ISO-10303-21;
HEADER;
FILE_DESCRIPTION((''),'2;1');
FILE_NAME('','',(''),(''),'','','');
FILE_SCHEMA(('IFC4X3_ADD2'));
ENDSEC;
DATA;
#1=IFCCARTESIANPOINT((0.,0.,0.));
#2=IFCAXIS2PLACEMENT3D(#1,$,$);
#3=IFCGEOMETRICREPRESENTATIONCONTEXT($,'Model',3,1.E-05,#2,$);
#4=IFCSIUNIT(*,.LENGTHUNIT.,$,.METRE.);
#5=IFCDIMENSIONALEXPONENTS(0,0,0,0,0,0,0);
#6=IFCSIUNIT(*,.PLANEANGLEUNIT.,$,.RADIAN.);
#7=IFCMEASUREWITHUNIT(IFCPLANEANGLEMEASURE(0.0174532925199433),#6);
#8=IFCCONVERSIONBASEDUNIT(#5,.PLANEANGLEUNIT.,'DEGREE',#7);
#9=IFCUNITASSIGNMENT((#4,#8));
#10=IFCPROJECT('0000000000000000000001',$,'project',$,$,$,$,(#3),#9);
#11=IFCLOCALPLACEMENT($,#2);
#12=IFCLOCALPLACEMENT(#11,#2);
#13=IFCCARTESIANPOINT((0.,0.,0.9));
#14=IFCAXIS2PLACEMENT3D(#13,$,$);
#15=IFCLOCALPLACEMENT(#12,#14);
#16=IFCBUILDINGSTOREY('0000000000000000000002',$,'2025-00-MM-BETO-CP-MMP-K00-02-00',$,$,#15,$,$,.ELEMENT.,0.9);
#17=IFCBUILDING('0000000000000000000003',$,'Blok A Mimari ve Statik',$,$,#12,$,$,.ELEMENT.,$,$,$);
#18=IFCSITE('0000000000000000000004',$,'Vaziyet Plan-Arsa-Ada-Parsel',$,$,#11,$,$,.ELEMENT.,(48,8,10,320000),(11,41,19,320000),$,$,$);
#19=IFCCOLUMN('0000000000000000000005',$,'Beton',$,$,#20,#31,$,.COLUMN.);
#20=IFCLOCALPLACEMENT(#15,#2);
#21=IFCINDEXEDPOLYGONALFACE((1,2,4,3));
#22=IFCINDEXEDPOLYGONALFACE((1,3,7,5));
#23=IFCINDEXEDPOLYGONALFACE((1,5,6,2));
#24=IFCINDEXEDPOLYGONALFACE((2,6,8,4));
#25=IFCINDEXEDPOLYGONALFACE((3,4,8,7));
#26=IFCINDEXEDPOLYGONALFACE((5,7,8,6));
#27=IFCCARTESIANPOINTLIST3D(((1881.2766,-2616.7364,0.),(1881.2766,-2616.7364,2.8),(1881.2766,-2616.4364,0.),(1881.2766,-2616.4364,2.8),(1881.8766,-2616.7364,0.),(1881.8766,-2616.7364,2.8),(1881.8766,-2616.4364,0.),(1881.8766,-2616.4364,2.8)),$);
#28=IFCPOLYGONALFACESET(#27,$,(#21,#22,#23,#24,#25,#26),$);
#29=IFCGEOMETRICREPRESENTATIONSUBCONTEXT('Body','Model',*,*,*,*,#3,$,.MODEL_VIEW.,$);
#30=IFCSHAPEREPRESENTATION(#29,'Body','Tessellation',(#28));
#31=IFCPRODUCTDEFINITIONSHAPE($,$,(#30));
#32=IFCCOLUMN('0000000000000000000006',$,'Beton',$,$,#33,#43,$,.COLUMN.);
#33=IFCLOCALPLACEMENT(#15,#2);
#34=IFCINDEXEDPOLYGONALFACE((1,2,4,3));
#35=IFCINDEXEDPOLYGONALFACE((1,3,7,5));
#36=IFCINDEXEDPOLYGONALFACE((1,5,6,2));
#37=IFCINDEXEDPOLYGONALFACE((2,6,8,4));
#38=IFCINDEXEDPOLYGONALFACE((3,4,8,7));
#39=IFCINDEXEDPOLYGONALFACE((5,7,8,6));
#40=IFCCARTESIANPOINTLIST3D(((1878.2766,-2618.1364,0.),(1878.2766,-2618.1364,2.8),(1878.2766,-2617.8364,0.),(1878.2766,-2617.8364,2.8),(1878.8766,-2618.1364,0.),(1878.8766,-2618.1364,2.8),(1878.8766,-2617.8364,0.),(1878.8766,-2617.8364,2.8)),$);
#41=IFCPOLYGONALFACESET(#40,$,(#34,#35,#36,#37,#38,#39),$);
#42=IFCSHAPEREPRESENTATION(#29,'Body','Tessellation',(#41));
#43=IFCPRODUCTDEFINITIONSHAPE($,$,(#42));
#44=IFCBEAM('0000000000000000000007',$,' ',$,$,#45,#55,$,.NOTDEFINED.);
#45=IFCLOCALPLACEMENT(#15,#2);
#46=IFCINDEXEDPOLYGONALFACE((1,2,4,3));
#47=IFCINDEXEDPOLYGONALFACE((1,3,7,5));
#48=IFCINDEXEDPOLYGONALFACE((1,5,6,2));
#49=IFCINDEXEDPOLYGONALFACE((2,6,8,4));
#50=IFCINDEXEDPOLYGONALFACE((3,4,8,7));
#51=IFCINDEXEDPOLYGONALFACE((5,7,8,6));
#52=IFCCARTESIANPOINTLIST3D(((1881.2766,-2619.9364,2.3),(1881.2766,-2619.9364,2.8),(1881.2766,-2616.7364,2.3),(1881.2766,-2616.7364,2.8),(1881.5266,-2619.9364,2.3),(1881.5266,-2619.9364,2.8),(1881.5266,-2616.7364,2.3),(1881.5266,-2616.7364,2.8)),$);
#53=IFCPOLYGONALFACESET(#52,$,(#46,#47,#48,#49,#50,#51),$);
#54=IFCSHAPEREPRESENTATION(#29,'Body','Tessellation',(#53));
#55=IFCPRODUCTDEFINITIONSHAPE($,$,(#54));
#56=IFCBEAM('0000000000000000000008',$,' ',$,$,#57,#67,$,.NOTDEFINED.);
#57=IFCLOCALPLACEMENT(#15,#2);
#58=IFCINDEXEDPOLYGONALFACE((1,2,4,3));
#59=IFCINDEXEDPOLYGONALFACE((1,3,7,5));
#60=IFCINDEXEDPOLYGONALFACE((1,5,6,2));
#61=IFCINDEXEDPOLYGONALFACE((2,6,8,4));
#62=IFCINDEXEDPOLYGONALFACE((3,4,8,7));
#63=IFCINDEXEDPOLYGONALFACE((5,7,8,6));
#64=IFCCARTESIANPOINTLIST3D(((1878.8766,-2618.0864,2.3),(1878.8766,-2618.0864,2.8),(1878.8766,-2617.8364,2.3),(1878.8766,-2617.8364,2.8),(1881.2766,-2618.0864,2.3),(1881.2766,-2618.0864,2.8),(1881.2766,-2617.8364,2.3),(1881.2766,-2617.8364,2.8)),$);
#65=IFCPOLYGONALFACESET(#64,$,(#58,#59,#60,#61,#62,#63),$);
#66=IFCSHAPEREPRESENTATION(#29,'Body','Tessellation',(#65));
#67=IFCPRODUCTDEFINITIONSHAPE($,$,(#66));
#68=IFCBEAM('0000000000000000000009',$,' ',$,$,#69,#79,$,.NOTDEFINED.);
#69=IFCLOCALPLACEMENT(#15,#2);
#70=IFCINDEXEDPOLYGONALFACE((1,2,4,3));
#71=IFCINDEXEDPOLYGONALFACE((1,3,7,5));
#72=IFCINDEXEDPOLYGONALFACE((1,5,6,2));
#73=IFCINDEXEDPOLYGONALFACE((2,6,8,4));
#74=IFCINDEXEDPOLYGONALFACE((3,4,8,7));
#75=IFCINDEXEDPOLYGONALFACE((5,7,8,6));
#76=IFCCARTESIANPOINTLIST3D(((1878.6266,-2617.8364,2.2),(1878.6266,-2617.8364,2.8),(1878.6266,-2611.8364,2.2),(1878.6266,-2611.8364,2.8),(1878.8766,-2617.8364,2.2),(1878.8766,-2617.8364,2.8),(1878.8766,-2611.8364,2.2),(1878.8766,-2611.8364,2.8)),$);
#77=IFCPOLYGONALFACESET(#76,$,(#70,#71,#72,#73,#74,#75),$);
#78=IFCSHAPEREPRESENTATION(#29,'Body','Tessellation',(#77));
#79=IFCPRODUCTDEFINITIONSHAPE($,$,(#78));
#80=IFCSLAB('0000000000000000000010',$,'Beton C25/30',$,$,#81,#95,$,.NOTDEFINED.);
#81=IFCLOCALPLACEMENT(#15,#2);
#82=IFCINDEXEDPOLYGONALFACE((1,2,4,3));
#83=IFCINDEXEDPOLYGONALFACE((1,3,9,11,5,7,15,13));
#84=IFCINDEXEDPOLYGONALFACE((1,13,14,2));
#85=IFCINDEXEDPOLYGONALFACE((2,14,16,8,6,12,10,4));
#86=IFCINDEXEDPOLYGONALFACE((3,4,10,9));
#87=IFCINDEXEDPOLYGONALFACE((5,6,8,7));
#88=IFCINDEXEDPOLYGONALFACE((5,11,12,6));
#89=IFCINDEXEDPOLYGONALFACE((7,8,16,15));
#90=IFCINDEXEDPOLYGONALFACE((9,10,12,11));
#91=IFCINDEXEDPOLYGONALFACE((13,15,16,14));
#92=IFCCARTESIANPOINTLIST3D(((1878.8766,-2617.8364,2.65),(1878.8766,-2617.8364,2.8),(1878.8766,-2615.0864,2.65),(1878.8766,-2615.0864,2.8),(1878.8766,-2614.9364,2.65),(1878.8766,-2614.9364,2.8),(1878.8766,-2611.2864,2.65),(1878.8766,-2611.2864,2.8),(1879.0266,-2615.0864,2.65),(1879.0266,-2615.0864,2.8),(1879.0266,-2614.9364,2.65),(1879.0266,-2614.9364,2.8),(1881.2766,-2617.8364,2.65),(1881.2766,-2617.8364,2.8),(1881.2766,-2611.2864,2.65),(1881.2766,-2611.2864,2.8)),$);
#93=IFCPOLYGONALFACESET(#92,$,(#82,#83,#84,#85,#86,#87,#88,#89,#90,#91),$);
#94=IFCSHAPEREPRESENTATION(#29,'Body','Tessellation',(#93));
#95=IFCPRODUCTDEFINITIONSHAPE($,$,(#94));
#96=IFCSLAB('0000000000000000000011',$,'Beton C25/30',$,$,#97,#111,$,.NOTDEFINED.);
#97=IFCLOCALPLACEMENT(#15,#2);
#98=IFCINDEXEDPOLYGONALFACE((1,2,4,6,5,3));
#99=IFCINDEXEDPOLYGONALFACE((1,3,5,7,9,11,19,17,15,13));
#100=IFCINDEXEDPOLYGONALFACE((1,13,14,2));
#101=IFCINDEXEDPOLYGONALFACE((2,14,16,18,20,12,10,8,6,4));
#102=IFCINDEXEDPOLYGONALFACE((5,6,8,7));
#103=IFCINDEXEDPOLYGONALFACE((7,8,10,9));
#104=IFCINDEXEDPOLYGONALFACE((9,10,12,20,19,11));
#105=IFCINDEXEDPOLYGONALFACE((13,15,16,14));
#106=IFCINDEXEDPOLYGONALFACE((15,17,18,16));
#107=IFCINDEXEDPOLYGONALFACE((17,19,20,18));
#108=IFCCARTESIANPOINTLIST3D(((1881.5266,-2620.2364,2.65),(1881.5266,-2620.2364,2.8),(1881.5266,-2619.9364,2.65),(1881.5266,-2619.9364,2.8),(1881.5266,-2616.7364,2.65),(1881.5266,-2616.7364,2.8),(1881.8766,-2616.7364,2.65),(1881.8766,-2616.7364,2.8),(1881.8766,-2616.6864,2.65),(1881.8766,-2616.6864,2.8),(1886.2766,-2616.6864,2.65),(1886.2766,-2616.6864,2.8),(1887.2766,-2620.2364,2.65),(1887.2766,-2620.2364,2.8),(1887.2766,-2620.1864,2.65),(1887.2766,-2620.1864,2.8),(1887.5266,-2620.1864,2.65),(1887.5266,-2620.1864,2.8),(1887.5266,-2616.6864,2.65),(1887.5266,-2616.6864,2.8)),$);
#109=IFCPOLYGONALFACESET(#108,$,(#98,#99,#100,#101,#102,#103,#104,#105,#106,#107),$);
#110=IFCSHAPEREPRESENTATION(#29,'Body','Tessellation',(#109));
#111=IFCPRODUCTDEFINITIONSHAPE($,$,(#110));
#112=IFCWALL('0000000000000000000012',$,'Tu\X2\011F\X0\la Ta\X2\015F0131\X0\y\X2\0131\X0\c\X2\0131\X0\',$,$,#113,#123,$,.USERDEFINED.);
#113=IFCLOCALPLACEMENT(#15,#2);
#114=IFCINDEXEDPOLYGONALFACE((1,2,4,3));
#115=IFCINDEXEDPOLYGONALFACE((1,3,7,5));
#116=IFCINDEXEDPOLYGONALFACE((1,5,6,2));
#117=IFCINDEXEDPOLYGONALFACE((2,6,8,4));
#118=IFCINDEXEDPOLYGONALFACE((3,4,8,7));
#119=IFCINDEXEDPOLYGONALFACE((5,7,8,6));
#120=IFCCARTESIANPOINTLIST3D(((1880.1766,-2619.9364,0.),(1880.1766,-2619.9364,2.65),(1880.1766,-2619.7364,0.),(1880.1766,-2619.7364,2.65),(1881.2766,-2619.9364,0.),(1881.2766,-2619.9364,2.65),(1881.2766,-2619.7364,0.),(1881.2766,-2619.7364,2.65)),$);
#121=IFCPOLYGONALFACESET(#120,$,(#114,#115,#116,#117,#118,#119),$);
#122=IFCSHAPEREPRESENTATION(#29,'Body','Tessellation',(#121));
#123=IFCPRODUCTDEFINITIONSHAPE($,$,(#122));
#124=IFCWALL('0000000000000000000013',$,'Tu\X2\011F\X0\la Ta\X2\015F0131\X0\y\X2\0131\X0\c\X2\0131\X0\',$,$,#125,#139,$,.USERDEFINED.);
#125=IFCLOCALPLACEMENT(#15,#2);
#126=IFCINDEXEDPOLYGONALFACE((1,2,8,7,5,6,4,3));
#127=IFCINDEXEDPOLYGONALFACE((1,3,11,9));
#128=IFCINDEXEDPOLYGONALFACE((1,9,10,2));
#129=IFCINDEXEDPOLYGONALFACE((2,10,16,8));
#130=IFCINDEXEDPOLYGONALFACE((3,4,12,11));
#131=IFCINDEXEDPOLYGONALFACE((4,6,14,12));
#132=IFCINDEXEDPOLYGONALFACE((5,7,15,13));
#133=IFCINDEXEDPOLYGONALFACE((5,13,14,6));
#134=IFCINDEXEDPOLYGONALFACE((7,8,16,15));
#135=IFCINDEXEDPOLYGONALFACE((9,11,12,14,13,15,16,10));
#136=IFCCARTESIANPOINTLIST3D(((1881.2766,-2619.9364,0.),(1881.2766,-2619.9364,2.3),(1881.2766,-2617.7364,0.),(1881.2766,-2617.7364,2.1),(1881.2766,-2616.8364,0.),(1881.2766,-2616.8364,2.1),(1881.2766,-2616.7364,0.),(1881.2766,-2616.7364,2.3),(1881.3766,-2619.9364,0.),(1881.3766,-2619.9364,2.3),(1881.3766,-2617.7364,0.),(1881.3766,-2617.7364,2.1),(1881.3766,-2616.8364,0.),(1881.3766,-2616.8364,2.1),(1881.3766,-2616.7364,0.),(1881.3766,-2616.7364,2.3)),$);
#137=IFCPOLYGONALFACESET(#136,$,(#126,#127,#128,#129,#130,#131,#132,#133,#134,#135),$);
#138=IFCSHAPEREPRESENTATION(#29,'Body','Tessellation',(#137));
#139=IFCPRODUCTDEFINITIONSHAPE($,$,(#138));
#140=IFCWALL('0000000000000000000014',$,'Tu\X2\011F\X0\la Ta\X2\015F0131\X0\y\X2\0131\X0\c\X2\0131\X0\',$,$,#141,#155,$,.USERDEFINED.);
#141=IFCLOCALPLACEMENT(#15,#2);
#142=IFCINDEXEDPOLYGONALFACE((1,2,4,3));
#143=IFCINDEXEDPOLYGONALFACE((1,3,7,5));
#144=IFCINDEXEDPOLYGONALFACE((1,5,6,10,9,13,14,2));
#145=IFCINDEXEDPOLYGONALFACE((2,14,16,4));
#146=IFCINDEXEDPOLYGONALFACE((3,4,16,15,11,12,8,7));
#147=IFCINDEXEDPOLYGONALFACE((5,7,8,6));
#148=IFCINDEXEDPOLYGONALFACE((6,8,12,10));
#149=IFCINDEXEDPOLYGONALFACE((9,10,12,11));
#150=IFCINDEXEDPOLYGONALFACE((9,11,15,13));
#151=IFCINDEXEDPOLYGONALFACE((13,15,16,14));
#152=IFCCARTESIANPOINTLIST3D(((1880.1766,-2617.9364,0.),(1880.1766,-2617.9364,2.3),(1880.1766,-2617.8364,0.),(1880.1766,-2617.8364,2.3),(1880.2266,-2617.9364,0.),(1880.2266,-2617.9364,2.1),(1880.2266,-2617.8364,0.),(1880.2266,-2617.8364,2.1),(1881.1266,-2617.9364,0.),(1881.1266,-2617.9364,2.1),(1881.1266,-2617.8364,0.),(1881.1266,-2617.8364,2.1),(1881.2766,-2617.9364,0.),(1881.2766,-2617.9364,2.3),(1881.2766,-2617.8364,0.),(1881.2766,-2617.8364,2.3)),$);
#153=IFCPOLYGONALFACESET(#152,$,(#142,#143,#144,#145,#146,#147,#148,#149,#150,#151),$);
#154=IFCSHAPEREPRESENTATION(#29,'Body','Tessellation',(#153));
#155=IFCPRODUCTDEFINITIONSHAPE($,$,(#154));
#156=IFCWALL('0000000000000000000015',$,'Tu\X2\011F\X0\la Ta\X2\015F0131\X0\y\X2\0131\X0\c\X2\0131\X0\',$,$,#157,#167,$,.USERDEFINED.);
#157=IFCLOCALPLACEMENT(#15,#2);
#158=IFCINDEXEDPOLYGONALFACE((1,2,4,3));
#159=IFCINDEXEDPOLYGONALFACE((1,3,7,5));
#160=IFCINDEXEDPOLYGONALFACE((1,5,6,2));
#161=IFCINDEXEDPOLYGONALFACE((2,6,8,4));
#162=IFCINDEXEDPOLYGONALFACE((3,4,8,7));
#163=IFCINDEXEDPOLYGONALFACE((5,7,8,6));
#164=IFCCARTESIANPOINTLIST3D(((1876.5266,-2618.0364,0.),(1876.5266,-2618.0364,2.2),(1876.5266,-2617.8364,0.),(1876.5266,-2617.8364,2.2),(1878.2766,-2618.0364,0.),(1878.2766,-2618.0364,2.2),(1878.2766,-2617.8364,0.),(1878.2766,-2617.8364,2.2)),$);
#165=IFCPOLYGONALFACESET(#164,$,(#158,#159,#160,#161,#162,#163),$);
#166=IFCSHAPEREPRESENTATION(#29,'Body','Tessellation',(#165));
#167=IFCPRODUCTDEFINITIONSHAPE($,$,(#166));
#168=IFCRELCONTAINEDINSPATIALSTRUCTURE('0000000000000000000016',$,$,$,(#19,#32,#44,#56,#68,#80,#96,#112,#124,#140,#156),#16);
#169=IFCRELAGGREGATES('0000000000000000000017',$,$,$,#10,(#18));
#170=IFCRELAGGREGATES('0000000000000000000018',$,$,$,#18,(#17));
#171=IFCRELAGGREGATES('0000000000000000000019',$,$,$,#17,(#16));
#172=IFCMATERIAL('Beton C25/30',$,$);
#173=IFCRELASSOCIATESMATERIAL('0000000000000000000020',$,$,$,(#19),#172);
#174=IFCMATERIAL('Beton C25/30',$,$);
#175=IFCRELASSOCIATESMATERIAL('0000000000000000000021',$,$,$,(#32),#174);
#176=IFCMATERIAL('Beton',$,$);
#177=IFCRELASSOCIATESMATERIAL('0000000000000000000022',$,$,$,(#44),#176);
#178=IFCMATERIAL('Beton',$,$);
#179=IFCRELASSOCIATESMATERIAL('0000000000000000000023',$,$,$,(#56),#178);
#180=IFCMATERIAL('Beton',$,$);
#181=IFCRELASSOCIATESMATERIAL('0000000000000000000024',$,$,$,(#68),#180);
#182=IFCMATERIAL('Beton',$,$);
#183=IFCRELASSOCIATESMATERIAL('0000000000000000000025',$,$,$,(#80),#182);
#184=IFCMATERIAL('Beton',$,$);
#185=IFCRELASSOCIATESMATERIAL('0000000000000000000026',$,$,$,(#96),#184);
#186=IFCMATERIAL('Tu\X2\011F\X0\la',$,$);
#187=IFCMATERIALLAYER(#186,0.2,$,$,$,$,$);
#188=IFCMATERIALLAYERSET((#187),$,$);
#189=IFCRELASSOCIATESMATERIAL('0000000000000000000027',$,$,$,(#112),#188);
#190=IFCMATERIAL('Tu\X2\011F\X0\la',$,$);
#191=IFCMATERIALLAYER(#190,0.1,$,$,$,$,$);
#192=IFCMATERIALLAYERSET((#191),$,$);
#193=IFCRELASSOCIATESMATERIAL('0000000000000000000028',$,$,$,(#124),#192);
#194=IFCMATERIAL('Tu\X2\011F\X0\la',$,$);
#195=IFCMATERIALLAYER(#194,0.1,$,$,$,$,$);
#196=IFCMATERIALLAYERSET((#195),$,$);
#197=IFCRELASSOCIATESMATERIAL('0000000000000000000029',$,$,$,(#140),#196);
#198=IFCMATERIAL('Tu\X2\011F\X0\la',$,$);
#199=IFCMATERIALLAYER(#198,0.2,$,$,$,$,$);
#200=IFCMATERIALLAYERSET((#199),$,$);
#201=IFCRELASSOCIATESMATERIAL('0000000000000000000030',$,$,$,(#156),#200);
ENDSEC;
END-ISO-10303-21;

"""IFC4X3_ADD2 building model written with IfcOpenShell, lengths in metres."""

from ifc_helpers import new_model, entity, si_unit, converted_unit, frame, frame_2d, origin, origin_with_axes, place, context, subcontext, project, spatial, polyline, rectangle, outline, extrude, material, layer, layer_set, layer_usage, element, save


model = new_model("IFC4X3_ADD2")

# Units and contexts
model_context = context("Model", 3, precision=1e-05, world=origin())
body_context = subcontext(model_context, "Body", "Model", "MODEL_VIEW")
ifc_project = project(units=[si_unit("LENGTHUNIT", "METRE"), converted_unit("PLANEANGLEUNIT", "DEGREE", entity("IfcPlaneAngleMeasure", 0.0174532925199433), si_unit("PLANEANGLEUNIT", "RADIAN"), dimensions=[0, 0, 0, 0, 0, 0, 0])], contexts=[model_context])

# Site, building, storey
site_placement = place(None, origin())
site = spatial("IfcSite", under=ifc_project, at=site_placement, Name="Vaziyet Plan-Arsa-Ada-Parsel", CompositionType="ELEMENT", RefLatitude=(48, 8, 10, 320000), RefLongitude=(11, 41, 19, 320000))
building_placement = place(site_placement, origin())
building = spatial("IfcBuilding", under=site, at=building_placement, Name="Blok A Mimari ve Statik", CompositionType="ELEMENT")
storey_placement = place(building_placement, frame((0.0, 0.0, 0.9)))
storey = spatial("IfcBuildingStorey", under=building, at=storey_placement, Name="2025-00-MM-BETO-CP-MMP-K00-02-00", CompositionType="ELEMENT", Elevation=0.9)

# Columns
ifc_material_1 = material(Name="Beton C25/30")
column_1_placement = place(storey_placement, frame((1881.2766, -2616.7364, 0.0)))
element("IfcColumn", 1, at=column_1_placement, inside=storey, material=ifc_material_1, Name="Beton", PredefinedType="COLUMN", context=body_context, shape_type="SweptSolid", body=[
    extrude(outline(polyline([(0.0, 0.0), (0.6, 0.0), (0.6, 0.3), (0.0, 0.3), (0.0, 0.0)])), origin_with_axes(), (0.0, 0.0, 1.0), 2.8),
])
ifc_material_2 = material(Name="Beton C25/30")
column_2_placement = place(storey_placement, frame((1878.2766, -2618.1364, 0.0)))
element("IfcColumn", 2, at=column_2_placement, inside=storey, material=ifc_material_2, Name="Beton", PredefinedType="COLUMN", context=body_context, shape_type="SweptSolid", body=[
    extrude(outline(polyline([(0.0, 0.3), (0.0, 0.0), (0.6, 0.0), (0.6, 0.3), (0.0, 0.3)])), origin_with_axes(), (0.0, 0.0, 1.0), 2.8),
])

# Beams
ifc_material_3 = material(Name="Beton")
beam_1_placement = place(storey_placement, frame((1881.2766, -2616.7364, 2.3), z_axis=(0.0, 0.0, 1.0), x_axis=(0.0, -1.0, 0.0)))
element("IfcBeam", 3, at=beam_1_placement, inside=storey, material=ifc_material_3, Name=" ", PredefinedType="NOTDEFINED", context=body_context, shape_type="SweptSolid", body=[
    extrude(rectangle(XDim=0.25, YDim=0.5, at=frame_2d((0.125, 0.25), x_axis=(1.0, 0.0))), frame((0.0, 0.0, 0.0), z_axis=(1.0, 0.0, 0.0), x_axis=(0.0, 1.0, 0.0)), (0.0, 0.0, 1.0), 3.2),
])
ifc_material_4 = material(Name="Beton")
beam_2_placement = place(storey_placement, frame((1878.8766, -2618.0864, 2.3), z_axis=(0.0, 0.0, 1.0), x_axis=(1.0, 0.0, 0.0)))
element("IfcBeam", 4, at=beam_2_placement, inside=storey, material=ifc_material_4, Name=" ", PredefinedType="NOTDEFINED", context=body_context, shape_type="SweptSolid", body=[
    extrude(rectangle(XDim=0.25, YDim=0.5, at=frame_2d((0.125, 0.25), x_axis=(1.0, 0.0))), frame((0.0, 0.0, 0.0), z_axis=(1.0, 0.0, 0.0), x_axis=(0.0, 1.0, 0.0)), (0.0, 0.0, 1.0), 2.4),
])
ifc_material_5 = material(Name="Beton")
beam_3_placement = place(storey_placement, frame((1878.8766, -2617.8364, 2.2), z_axis=(0.0, 0.0, 1.0), x_axis=(0.0, 1.0, 0.0)))
element("IfcBeam", 5, at=beam_3_placement, inside=storey, material=ifc_material_5, Name=" ", PredefinedType="NOTDEFINED", context=body_context, shape_type="SweptSolid", body=[
    extrude(rectangle(XDim=0.25, YDim=0.6, at=frame_2d((0.125, 0.3), x_axis=(1.0, 0.0))), frame((0.0, 0.0, 0.0), z_axis=(1.0, 0.0, 0.0), x_axis=(0.0, 1.0, 0.0)), (0.0, 0.0, 1.0), 6.0),
])

# Slab, opening
ifc_material_6 = material(Name="Beton")
slab_1_placement = place(storey_placement, frame((1878.8766, -2617.8364, 2.65)))
slab_1 = element("IfcSlab", 6, at=slab_1_placement, inside=storey, material=ifc_material_6, Name="Beton C25/30", PredefinedType="NOTDEFINED", context=body_context, shape_type="SweptSolid", body=[
    extrude(rectangle(XDim=2.4, YDim=6.55, at=frame_2d((1.2, 3.275), x_axis=(1.0, 0.0))), origin_with_axes(), (0.0, 0.0, 1.0), 0.15),
])
opening_1_placement = place(slab_1_placement, frame((0.0, 2.75, 0.0)))
element("IfcOpeningElement", 7, at=opening_1_placement, cuts=slab_1, PredefinedType="OPENING", context=body_context, shape_type="SweptSolid", body=[
    extrude(rectangle(XDim=0.15, YDim=0.15, at=frame_2d((0.0, 0.0), x_axis=(0.0, -1.0))), frame((0.075, 0.075, 0.0), z_axis=(0.0, 0.0, 1.0), x_axis=(1.0, 0.0, 0.0)), (0.0, 0.0, 1.0), 0.15),
])

# Slab
ifc_material_7 = material(Name="Beton")
slab_2_placement = place(storey_placement, frame((1881.5266, -2620.2364, 2.65)))
element("IfcSlab", 8, at=slab_2_placement, inside=storey, material=ifc_material_7, Name="Beton C25/30", PredefinedType="NOTDEFINED", context=body_context, shape_type="SweptSolid", body=[
    extrude(outline(polyline([(0.35, 3.55), (0.35, 3.5), (0.0, 3.5), (0.0, 0.3), (0.0, 0.0), (5.75, 0.0), (5.75, 0.05), (6.0, 0.05), (6.0, 3.55), (4.75, 3.55), (0.35, 3.55)])), origin_with_axes(), (0.0, 0.0, 1.0), 0.15),
])

# Wall
ifc_material_8 = material(Name="Tuğla")
ifc_layer_1 = layer(ifc_material_8, 0.2)
ifc_layer_set_1 = layer_set([ifc_layer_1])
ifc_layer_usage_1 = layer_usage(ifc_layer_set_1, "AXIS2", "POSITIVE", 0.0)
wall_1_placement = place(storey_placement, frame((1880.1766, -2619.9364, 0.0), z_axis=(0.0, 0.0, 1.0), x_axis=(1.0, -0.000002, 0.0)))
element("IfcWall", 9, at=wall_1_placement, inside=storey, material=ifc_layer_usage_1, Name="Tuğla Taşıyıcı", PredefinedType="USERDEFINED", context=body_context, shape_type="SweptSolid", body=[
    extrude(rectangle(XDim=1.1, YDim=0.2, at=frame_2d((0.55, 0.1), x_axis=(1.0, 0.0))), origin_with_axes(), (0.0, 0.0, 1.0), 2.65),
])

# Walls, openings
ifc_material_9 = material(Name="Tuğla")
ifc_layer_2 = layer(ifc_material_9, 0.1)
ifc_layer_set_2 = layer_set([ifc_layer_2])
ifc_layer_usage_2 = layer_usage(ifc_layer_set_2, "AXIS2", "POSITIVE", 0.0)
wall_2_placement = place(storey_placement, frame((1881.2766, -2616.7364, 0.0), z_axis=(0.0, 0.0, 1.0), x_axis=(0.0, -1.0, 0.0)))
wall_2 = element("IfcWall", 10, at=wall_2_placement, inside=storey, material=ifc_layer_usage_2, Name="Tuğla Taşıyıcı", PredefinedType="USERDEFINED", context=body_context, shape_type="SweptSolid", body=[
    extrude(rectangle(XDim=3.2, YDim=0.1, at=frame_2d((1.6, 0.05), x_axis=(1.0, 0.0))), origin_with_axes(), (0.0, 0.0, 1.0), 2.3),
])
opening_2_placement = place(wall_2_placement, frame((1.0, 0.1, 0.0), z_axis=(0.0, -1.0, 0.0), x_axis=(0.0, 0.0, 1.0)))
element("IfcOpeningElement", 11, at=opening_2_placement, cuts=wall_2, PredefinedType="OPENING", context=body_context, shape_type="SweptSolid", body=[
    extrude(outline(polyline([(2.1, 0.9), (2.1, 0.0), (0.0, 0.0), (0.0, 0.9), (2.1, 0.9)])), origin_with_axes(), (0.0, 0.0, 1.0), 0.1),
])
ifc_material_10 = material(Name="Tuğla")
ifc_layer_3 = layer(ifc_material_10, 0.1)
ifc_layer_set_3 = layer_set([ifc_layer_3])
ifc_layer_usage_3 = layer_usage(ifc_layer_set_3, "AXIS2", "POSITIVE", 0.0)
wall_3_placement = place(storey_placement, frame((1881.2766, -2617.8364, 0.0), z_axis=(0.0, 0.0, 1.0), x_axis=(-1.0, 0.0, 0.0)))
wall_3 = element("IfcWall", 12, at=wall_3_placement, inside=storey, material=ifc_layer_usage_3, Name="Tuğla Taşıyıcı", PredefinedType="USERDEFINED", context=body_context, shape_type="SweptSolid", body=[
    extrude(rectangle(XDim=1.1, YDim=0.1, at=frame_2d((0.55, 0.05), x_axis=(1.0, 0.0))), origin_with_axes(), (0.0, 0.0, 1.0), 2.3),
])
opening_3_placement = place(wall_3_placement, frame((0.15, 0.0, 0.0), z_axis=(0.0, 1.0, 0.0), x_axis=(0.0, 0.0, 1.0)))
element("IfcOpeningElement", 13, at=opening_3_placement, cuts=wall_3, PredefinedType="OPENING", context=body_context, shape_type="SweptSolid", body=[
    extrude(outline(polyline([(2.1, 0.9), (2.1, 0.0), (0.0, 0.0), (0.0, 0.9), (2.1, 0.9)])), origin_with_axes(), (0.0, 0.0, 1.0), 0.1),
])

# Wall
ifc_material_11 = material(Name="Tuğla")
ifc_layer_4 = layer(ifc_material_11, 0.2)
ifc_layer_set_4 = layer_set([ifc_layer_4])
ifc_layer_usage_4 = layer_usage(ifc_layer_set_4, "AXIS2", "POSITIVE", 0.0)
wall_4_placement = place(storey_placement, frame((1876.5266, -2618.0364, 0.0)))
element("IfcWall", 14, at=wall_4_placement, inside=storey, material=ifc_layer_usage_4, Name="Tuğla Taşıyıcı", PredefinedType="USERDEFINED", context=body_context, shape_type="SweptSolid", body=[
    extrude(rectangle(XDim=1.75, YDim=0.2, at=frame_2d((0.875, 0.1), x_axis=(1.0, 0.0))), origin_with_axes(), (0.0, 0.0, 1.0), 2.2),
])

save(model, "model.ifc")
